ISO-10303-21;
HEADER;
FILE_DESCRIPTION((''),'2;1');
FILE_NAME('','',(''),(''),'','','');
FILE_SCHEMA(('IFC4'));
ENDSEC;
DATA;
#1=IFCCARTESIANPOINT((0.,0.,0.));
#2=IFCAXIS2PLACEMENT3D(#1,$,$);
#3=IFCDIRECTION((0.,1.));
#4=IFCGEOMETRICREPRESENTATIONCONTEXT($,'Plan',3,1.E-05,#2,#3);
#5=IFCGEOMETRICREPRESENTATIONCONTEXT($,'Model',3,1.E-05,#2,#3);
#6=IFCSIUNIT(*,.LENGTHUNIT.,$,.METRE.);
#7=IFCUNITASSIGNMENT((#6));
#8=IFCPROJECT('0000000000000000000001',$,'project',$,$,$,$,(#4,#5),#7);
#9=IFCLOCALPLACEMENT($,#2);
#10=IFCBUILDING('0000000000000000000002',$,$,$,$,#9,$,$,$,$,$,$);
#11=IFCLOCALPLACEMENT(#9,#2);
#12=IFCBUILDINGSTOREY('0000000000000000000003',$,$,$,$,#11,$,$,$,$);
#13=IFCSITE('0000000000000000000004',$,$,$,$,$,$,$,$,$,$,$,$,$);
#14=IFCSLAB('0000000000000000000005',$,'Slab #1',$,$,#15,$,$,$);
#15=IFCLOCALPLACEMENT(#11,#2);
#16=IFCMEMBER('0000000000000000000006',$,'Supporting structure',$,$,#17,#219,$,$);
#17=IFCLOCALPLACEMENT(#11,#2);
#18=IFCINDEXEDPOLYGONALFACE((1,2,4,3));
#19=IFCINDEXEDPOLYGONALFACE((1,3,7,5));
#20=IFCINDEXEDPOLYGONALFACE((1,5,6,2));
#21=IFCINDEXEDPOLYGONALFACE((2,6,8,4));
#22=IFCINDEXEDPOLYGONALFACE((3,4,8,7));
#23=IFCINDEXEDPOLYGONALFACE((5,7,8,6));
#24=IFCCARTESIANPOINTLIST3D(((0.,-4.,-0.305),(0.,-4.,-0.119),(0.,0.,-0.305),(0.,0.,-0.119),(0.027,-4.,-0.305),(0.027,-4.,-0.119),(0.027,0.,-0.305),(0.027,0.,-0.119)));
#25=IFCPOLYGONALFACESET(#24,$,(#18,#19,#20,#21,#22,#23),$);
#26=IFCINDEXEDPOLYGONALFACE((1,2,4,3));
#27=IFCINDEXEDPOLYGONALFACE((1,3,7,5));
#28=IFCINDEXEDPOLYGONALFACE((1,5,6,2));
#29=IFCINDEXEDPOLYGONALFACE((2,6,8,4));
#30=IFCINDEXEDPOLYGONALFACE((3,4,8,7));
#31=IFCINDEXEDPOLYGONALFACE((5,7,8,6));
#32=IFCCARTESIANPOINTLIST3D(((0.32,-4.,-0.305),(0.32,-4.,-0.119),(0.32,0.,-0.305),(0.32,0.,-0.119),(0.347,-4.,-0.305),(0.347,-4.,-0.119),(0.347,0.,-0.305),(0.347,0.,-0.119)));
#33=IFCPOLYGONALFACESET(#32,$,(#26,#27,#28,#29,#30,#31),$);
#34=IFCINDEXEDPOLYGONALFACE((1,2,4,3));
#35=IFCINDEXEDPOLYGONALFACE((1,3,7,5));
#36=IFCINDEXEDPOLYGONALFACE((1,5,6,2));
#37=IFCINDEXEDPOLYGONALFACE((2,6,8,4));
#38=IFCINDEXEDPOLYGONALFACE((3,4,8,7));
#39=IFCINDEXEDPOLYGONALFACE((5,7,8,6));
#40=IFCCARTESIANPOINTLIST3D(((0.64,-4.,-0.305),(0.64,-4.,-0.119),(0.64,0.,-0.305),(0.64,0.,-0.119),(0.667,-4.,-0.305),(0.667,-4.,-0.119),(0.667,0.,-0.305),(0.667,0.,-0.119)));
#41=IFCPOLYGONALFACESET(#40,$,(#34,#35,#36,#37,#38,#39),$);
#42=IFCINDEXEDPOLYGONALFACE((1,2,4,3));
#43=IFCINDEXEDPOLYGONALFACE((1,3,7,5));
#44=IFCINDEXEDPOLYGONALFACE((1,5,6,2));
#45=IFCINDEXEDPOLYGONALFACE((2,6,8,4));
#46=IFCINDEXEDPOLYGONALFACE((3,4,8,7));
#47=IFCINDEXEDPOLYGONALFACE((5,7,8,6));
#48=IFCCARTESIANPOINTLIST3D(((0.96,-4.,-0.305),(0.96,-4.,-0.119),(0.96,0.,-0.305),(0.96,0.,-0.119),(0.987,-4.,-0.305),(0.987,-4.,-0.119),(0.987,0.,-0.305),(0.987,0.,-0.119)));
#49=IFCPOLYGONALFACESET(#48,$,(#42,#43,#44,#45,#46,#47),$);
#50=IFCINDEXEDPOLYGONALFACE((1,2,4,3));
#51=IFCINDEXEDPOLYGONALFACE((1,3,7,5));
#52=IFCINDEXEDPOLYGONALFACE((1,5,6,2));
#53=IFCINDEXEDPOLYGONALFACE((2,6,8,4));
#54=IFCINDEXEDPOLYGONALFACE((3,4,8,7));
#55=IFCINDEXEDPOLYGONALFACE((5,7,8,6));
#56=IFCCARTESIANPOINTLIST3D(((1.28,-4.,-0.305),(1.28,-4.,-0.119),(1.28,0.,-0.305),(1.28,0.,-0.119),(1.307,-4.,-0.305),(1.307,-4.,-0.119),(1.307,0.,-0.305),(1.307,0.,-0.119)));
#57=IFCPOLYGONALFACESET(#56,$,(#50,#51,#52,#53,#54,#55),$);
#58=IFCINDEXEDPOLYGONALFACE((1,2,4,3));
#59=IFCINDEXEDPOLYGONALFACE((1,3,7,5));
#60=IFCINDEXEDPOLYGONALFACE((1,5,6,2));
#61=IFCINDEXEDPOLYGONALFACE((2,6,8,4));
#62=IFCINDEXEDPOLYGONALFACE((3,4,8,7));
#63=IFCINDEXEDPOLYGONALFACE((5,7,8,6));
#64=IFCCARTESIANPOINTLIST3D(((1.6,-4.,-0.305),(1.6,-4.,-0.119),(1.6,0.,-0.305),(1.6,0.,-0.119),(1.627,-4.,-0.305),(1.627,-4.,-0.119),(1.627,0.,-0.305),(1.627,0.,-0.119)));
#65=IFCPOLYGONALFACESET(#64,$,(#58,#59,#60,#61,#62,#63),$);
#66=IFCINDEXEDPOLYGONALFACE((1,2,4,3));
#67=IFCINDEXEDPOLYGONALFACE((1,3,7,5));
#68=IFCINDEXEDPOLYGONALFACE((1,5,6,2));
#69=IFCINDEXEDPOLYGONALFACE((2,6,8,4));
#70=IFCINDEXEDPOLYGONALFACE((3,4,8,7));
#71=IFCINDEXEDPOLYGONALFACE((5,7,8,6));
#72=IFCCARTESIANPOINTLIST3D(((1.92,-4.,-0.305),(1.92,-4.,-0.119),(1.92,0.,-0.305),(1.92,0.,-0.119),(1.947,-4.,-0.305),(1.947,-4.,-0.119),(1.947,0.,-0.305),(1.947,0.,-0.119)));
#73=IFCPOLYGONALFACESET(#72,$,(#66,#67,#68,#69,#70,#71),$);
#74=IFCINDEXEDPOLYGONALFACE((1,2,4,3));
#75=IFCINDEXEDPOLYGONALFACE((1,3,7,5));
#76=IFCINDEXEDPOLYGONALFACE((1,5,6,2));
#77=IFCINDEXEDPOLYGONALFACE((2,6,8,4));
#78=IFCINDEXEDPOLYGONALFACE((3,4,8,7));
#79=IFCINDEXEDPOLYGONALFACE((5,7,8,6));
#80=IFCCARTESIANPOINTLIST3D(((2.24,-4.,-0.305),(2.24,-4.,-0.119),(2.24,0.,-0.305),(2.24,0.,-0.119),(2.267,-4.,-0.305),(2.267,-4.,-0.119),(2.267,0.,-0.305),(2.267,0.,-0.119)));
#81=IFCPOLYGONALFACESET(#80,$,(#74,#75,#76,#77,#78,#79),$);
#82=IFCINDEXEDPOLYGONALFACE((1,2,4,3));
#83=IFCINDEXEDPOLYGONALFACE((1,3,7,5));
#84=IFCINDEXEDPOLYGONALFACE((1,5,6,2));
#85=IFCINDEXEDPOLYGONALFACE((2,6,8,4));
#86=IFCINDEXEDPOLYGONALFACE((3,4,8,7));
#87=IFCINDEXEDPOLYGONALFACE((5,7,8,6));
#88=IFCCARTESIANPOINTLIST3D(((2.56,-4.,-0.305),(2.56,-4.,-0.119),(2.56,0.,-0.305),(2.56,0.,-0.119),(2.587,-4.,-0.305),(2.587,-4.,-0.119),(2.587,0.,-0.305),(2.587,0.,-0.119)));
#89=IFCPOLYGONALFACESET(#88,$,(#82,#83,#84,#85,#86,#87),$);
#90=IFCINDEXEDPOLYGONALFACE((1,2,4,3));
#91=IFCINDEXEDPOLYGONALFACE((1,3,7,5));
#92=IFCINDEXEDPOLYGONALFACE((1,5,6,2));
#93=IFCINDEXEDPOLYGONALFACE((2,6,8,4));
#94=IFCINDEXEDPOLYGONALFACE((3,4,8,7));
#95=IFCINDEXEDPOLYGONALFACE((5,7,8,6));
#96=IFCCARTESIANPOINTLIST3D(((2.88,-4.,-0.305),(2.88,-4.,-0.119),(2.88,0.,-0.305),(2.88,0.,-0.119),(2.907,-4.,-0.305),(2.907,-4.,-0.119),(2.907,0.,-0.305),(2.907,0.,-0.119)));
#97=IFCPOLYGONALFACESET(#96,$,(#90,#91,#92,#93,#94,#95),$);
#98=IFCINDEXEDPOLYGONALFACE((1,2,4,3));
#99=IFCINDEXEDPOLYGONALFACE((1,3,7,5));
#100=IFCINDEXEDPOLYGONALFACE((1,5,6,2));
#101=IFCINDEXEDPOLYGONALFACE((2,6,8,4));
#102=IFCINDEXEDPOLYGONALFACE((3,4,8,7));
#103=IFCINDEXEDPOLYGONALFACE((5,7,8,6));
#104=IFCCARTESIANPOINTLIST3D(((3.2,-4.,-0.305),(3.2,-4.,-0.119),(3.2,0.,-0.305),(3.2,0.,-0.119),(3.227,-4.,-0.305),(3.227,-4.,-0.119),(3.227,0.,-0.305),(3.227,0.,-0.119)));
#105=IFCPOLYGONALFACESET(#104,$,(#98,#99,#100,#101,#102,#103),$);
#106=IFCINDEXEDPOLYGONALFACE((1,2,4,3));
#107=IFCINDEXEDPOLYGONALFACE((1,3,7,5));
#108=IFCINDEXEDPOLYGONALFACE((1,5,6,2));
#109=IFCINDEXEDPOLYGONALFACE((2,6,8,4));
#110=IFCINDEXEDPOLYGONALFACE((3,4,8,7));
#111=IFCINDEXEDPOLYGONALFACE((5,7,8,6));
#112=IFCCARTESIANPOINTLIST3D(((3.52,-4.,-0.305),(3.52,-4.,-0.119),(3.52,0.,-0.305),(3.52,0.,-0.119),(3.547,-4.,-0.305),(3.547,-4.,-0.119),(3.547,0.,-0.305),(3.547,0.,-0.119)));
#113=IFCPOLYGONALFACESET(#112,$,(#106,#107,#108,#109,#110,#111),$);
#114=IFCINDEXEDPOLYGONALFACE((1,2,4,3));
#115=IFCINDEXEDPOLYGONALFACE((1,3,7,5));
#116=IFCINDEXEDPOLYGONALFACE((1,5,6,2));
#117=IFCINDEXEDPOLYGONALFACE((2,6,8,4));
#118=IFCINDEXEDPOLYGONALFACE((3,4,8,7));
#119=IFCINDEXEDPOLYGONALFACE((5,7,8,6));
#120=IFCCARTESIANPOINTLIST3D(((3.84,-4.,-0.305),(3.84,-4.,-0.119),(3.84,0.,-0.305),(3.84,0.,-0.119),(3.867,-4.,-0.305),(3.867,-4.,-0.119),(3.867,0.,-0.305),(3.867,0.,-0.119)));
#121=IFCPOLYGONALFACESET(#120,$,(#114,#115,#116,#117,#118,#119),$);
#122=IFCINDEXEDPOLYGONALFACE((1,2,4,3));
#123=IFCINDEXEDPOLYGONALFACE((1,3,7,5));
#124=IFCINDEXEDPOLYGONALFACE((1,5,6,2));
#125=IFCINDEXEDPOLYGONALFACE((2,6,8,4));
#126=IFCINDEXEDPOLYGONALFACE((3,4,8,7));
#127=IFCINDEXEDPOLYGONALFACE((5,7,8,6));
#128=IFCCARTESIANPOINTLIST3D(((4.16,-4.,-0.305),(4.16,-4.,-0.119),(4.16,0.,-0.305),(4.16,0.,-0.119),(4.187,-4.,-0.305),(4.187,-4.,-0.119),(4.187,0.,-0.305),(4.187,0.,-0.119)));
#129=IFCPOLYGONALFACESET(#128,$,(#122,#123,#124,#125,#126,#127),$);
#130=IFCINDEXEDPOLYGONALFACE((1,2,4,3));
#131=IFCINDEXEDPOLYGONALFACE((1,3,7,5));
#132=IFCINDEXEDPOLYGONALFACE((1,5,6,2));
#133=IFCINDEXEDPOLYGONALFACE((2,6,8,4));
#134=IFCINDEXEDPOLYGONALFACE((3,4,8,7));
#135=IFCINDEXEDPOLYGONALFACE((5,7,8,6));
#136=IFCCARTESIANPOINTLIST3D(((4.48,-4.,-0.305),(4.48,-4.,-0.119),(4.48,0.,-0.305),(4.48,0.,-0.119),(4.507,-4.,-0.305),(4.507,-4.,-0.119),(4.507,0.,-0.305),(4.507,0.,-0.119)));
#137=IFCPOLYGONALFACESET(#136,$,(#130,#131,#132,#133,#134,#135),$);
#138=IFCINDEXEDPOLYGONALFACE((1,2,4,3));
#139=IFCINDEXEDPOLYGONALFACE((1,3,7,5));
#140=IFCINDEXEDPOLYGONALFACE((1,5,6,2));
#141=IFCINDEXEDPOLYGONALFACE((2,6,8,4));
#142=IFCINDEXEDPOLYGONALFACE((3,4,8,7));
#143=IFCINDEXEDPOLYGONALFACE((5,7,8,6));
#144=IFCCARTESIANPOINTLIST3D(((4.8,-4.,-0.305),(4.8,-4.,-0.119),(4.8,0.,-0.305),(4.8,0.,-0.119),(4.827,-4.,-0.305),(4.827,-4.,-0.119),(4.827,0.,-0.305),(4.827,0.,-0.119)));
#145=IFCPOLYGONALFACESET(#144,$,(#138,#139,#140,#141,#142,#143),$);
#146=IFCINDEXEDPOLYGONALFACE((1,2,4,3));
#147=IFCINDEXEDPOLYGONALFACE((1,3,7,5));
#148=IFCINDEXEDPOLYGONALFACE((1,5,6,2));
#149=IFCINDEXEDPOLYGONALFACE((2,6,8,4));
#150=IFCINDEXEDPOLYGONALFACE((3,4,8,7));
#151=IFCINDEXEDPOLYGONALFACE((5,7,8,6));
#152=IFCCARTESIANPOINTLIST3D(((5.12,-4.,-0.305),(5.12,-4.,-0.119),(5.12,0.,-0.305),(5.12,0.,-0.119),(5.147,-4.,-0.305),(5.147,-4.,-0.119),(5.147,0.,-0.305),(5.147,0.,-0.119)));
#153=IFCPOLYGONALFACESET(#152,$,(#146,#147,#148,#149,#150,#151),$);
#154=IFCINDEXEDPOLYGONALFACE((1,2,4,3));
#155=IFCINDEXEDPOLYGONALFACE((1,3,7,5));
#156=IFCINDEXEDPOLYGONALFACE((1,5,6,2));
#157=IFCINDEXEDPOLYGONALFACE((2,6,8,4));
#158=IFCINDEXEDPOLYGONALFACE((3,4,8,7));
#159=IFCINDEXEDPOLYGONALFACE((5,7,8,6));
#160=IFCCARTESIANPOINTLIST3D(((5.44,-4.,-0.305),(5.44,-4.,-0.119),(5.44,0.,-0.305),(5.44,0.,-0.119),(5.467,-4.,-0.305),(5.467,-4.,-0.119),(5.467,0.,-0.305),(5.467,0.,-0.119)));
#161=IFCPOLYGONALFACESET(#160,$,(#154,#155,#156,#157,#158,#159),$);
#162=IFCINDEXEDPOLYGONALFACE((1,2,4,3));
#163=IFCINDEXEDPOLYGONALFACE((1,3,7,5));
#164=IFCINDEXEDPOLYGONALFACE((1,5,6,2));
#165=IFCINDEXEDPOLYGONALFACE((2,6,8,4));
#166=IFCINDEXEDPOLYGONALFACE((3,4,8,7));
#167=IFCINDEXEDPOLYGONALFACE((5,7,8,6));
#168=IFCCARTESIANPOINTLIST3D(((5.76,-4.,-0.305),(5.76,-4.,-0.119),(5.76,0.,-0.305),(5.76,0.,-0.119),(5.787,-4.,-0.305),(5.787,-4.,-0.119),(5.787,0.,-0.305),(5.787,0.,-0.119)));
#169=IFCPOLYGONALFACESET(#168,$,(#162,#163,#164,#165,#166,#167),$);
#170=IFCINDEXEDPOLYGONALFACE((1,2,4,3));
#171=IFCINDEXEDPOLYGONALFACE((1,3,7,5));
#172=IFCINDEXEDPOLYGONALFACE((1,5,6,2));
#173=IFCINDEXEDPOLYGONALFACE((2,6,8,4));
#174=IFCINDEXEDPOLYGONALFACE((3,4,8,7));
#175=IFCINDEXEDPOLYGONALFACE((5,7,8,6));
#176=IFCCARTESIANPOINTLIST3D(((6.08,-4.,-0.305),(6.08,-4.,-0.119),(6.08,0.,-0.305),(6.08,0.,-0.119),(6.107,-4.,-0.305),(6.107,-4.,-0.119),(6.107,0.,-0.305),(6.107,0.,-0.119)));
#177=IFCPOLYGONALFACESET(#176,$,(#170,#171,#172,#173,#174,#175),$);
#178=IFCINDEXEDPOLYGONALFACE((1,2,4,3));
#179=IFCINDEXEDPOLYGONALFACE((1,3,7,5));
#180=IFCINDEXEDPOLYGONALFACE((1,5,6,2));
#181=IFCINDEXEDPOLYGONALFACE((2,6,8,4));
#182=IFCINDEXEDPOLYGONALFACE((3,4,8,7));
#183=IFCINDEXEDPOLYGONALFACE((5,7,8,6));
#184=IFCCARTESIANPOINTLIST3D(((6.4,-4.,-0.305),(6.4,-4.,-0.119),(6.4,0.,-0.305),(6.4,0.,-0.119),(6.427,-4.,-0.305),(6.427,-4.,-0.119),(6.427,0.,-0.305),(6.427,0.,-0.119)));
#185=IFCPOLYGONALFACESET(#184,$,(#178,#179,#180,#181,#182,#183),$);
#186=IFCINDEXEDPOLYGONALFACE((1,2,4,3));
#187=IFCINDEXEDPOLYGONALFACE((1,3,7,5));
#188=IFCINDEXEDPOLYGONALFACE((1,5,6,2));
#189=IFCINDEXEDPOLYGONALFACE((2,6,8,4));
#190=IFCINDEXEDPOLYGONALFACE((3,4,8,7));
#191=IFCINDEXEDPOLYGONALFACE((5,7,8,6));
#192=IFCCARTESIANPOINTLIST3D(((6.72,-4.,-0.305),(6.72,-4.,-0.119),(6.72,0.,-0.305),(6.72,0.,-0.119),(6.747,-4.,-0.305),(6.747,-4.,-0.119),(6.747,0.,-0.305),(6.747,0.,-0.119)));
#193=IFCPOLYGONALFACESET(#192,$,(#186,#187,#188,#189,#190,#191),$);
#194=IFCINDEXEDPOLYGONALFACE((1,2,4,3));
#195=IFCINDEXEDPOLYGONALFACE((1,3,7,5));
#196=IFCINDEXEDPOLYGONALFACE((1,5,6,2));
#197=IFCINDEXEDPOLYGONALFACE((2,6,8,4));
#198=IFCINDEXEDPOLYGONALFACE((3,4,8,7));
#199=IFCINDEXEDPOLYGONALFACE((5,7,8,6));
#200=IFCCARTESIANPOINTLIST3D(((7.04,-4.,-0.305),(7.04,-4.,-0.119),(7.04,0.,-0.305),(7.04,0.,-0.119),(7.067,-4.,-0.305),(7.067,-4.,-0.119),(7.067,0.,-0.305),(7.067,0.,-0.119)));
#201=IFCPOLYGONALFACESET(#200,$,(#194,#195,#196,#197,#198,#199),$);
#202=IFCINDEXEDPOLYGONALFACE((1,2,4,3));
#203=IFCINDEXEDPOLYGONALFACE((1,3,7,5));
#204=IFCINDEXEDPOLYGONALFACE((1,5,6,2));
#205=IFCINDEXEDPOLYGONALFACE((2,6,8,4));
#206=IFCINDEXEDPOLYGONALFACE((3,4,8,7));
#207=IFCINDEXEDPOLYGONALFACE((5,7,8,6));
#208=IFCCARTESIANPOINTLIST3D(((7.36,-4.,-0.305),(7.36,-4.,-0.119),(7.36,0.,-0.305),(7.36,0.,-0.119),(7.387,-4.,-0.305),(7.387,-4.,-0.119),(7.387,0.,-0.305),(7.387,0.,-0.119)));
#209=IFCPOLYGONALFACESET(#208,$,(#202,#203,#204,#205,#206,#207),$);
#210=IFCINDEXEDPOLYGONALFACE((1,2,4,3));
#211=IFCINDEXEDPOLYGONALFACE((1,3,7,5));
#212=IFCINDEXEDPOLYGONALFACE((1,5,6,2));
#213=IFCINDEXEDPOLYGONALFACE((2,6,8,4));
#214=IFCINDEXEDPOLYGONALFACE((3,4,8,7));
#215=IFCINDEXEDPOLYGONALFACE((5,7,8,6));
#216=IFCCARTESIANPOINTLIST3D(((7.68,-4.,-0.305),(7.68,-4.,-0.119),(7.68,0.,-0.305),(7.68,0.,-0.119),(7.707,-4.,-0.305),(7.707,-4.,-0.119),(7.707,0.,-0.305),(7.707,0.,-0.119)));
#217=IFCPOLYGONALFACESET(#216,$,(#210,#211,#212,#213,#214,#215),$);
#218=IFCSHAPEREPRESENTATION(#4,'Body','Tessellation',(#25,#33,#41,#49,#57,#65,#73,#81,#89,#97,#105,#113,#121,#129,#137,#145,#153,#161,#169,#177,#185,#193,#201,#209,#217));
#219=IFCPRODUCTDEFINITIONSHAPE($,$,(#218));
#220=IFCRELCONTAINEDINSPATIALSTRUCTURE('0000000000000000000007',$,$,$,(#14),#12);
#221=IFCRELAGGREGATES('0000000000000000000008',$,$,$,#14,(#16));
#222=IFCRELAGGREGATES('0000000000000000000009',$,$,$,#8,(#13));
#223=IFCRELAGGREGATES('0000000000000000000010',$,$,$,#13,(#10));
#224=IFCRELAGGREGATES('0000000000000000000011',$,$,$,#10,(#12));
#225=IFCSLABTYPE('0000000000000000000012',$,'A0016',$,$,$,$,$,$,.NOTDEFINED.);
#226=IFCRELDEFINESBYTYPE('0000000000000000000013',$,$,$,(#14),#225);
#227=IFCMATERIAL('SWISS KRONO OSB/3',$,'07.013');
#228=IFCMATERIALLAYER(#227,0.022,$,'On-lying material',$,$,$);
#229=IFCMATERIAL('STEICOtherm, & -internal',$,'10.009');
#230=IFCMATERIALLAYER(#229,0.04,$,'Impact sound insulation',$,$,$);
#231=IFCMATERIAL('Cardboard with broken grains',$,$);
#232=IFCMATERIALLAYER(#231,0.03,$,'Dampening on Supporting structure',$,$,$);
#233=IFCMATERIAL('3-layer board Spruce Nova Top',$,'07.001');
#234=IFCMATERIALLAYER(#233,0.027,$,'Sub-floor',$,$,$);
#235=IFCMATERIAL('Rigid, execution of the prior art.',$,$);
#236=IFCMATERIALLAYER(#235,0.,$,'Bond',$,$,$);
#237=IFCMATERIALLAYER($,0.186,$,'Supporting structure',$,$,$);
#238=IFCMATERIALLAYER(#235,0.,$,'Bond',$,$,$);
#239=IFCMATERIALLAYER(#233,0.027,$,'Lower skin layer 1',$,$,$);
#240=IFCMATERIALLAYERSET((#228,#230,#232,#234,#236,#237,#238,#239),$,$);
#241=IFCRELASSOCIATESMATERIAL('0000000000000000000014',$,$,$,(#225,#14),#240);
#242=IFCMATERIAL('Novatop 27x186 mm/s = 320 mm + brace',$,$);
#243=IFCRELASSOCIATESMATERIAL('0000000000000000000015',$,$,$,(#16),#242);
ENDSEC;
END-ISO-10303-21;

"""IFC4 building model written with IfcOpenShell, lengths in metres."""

from ifc_helpers import new_model, si_unit, direction, frame, frame_2d, origin, place, context, project, spatial, rectangle, extrude, material, layer, layer_set, type_object, element, aggregate, save


model = new_model("IFC4")

# Units and contexts
plan_context = context("Plan", 3, precision=1e-05, world=origin(), true_north=direction((0.0, 1.0)))
model_context = context("Model", 3, precision=1e-05, world=origin(), true_north=direction((0.0, 1.0)))
ifc_project = project(units=[si_unit("LENGTHUNIT", "METRE")], contexts=[plan_context, model_context])

# Site, building, storey
site = spatial("IfcSite", under=ifc_project)
building_placement = place(None, origin())
building = spatial("IfcBuilding", under=site, at=building_placement)
storey_placement = place(building_placement, origin())
storey = spatial("IfcBuildingStorey", under=building, at=storey_placement)

# Slab, member
ifc_material_1 = material(Name="SWISS KRONO OSB/3", Category="07.013")
ifc_layer_1 = layer(ifc_material_1, 0.022, Name="On-lying material")
ifc_material_2 = material(Name="STEICOtherm, & -internal", Category="10.009")
ifc_layer_2 = layer(ifc_material_2, 0.04, Name="Impact sound insulation")
ifc_material_3 = material(Name="Cardboard with broken grains")
ifc_layer_3 = layer(ifc_material_3, 0.03, Name="Dampening on Supporting structure")
ifc_material_4 = material(Name="3-layer board Spruce Nova Top", Category="07.001")
ifc_layer_4 = layer(ifc_material_4, 0.027, Name="Sub-floor")
ifc_material_5 = material(Name="Rigid, execution of the prior art.")
ifc_layer_5 = layer(ifc_material_5, 0.0, Name="Bond")
ifc_layer_6 = layer(None, 0.186, Name="Supporting structure")
ifc_layer_7 = layer(ifc_material_5, 0.0, Name="Bond")
ifc_layer_8 = layer(ifc_material_4, 0.027, Name="Lower skin layer 1")
ifc_layer_set = layer_set([ifc_layer_1, ifc_layer_2, ifc_layer_3, ifc_layer_4, ifc_layer_5, ifc_layer_6, ifc_layer_7, ifc_layer_8])
slab_type = type_object("IfcSlabType", Name="A0016", PredefinedType="NOTDEFINED", material=ifc_layer_set)
slab_placement = place(None, frame((0.0, 0.0, 0.0), z_axis=(0.0, 0.0, -1.0), x_axis=(1.0, 0.0, 0.0)))
slab = element("IfcSlab", 1, at=slab_placement, inside=storey, type_object=slab_type, material=ifc_layer_set, Name="Slab #1")
ifc_material_6 = material(Name="Novatop 27x186 mm/s = 320 mm + brace")
member_1_placement = place(slab_placement, origin())
member_1 = element("IfcMember", 2, at=member_1_placement, material=ifc_material_6, Name="Supporting structure", context=plan_context, shape_type="SweptSolid", body=[
    extrude(rectangle(XDim=0.027, YDim=0.186, at=frame_2d((0.0135, 0.093), x_axis=(1.0, 0.0))), frame((0.0, 4.0, 0.119), z_axis=(0.0, -1.0, 0.0), x_axis=(1.0, 0.0, 0.0)), (0.0, 0.0, 1.0), 4.0),
    extrude(rectangle(XDim=0.027, YDim=0.186, at=frame_2d((0.0135, 0.093), x_axis=(1.0, 0.0))), frame((0.32, 4.0, 0.119), z_axis=(0.0, -1.0, 0.0), x_axis=(1.0, 0.0, 0.0)), (0.0, 0.0, 1.0), 4.0),
    extrude(rectangle(XDim=0.027, YDim=0.186, at=frame_2d((0.0135, 0.093), x_axis=(1.0, 0.0))), frame((0.64, 4.0, 0.119), z_axis=(0.0, -1.0, 0.0), x_axis=(1.0, 0.0, 0.0)), (0.0, 0.0, 1.0), 4.0),
    extrude(rectangle(XDim=0.027, YDim=0.186, at=frame_2d((0.0135, 0.093), x_axis=(1.0, 0.0))), frame((0.96, 4.0, 0.119), z_axis=(0.0, -1.0, 0.0), x_axis=(1.0, 0.0, 0.0)), (0.0, 0.0, 1.0), 4.0),
    extrude(rectangle(XDim=0.027, YDim=0.186, at=frame_2d((0.0135, 0.093), x_axis=(1.0, 0.0))), frame((1.28, 4.0, 0.119), z_axis=(0.0, -1.0, 0.0), x_axis=(1.0, 0.0, 0.0)), (0.0, 0.0, 1.0), 4.0),
    extrude(rectangle(XDim=0.027, YDim=0.186, at=frame_2d((0.0135, 0.093), x_axis=(1.0, 0.0))), frame((1.6, 4.0, 0.119), z_axis=(0.0, -1.0, 0.0), x_axis=(1.0, 0.0, 0.0)), (0.0, 0.0, 1.0), 4.0),
    extrude(rectangle(XDim=0.027, YDim=0.186, at=frame_2d((0.0135, 0.093), x_axis=(1.0, 0.0))), frame((1.92, 4.0, 0.119), z_axis=(0.0, -1.0, 0.0), x_axis=(1.0, 0.0, 0.0)), (0.0, 0.0, 1.0), 4.0),
    extrude(rectangle(XDim=0.027, YDim=0.186, at=frame_2d((0.0135, 0.093), x_axis=(1.0, 0.0))), frame((2.24, 4.0, 0.119), z_axis=(0.0, -1.0, 0.0), x_axis=(1.0, 0.0, 0.0)), (0.0, 0.0, 1.0), 4.0),
    extrude(rectangle(XDim=0.027, YDim=0.186, at=frame_2d((0.0135, 0.093), x_axis=(1.0, 0.0))), frame((2.56, 4.0, 0.119), z_axis=(0.0, -1.0, 0.0), x_axis=(1.0, 0.0, 0.0)), (0.0, 0.0, 1.0), 4.0),
    extrude(rectangle(XDim=0.027, YDim=0.186, at=frame_2d((0.0135, 0.093), x_axis=(1.0, 0.0))), frame((2.88, 4.0, 0.119), z_axis=(0.0, -1.0, 0.0), x_axis=(1.0, 0.0, 0.0)), (0.0, 0.0, 1.0), 4.0),
    extrude(rectangle(XDim=0.027, YDim=0.186, at=frame_2d((0.0135, 0.093), x_axis=(1.0, 0.0))), frame((3.2, 4.0, 0.119), z_axis=(0.0, -1.0, 0.0), x_axis=(1.0, 0.0, 0.0)), (0.0, 0.0, 1.0), 4.0),
    extrude(rectangle(XDim=0.027, YDim=0.186, at=frame_2d((0.0135, 0.093), x_axis=(1.0, 0.0))), frame((3.52, 4.0, 0.119), z_axis=(0.0, -1.0, 0.0), x_axis=(1.0, 0.0, 0.0)), (0.0, 0.0, 1.0), 4.0),
    extrude(rectangle(XDim=0.027, YDim=0.186, at=frame_2d((0.0135, 0.093), x_axis=(1.0, 0.0))), frame((3.84, 4.0, 0.119), z_axis=(0.0, -1.0, 0.0), x_axis=(1.0, 0.0, 0.0)), (0.0, 0.0, 1.0), 4.0),
    extrude(rectangle(XDim=0.027, YDim=0.186, at=frame_2d((0.0135, 0.093), x_axis=(1.0, 0.0))), frame((4.16, 4.0, 0.119), z_axis=(0.0, -1.0, 0.0), x_axis=(1.0, 0.0, 0.0)), (0.0, 0.0, 1.0), 4.0),
    extrude(rectangle(XDim=0.027, YDim=0.186, at=frame_2d((0.0135, 0.093), x_axis=(1.0, 0.0))), frame((4.48, 4.0, 0.119), z_axis=(0.0, -1.0, 0.0), x_axis=(1.0, 0.0, 0.0)), (0.0, 0.0, 1.0), 4.0),
    extrude(rectangle(XDim=0.027, YDim=0.186, at=frame_2d((0.0135, 0.093), x_axis=(1.0, 0.0))), frame((4.8, 4.0, 0.119), z_axis=(0.0, -1.0, 0.0), x_axis=(1.0, 0.0, 0.0)), (0.0, 0.0, 1.0), 4.0),
    extrude(rectangle(XDim=0.027, YDim=0.186, at=frame_2d((0.0135, 0.093), x_axis=(1.0, 0.0))), frame((5.12, 4.0, 0.119), z_axis=(0.0, -1.0, 0.0), x_axis=(1.0, 0.0, 0.0)), (0.0, 0.0, 1.0), 4.0),
    extrude(rectangle(XDim=0.027, YDim=0.186, at=frame_2d((0.0135, 0.093), x_axis=(1.0, 0.0))), frame((5.44, 4.0, 0.119), z_axis=(0.0, -1.0, 0.0), x_axis=(1.0, 0.0, 0.0)), (0.0, 0.0, 1.0), 4.0),
    extrude(rectangle(XDim=0.027, YDim=0.186, at=frame_2d((0.0135, 0.093), x_axis=(1.0, 0.0))), frame((5.76, 4.0, 0.119), z_axis=(0.0, -1.0, 0.0), x_axis=(1.0, 0.0, 0.0)), (0.0, 0.0, 1.0), 4.0),
    extrude(rectangle(XDim=0.027, YDim=0.186, at=frame_2d((0.0135, 0.093), x_axis=(1.0, 0.0))), frame((6.08, 4.0, 0.119), z_axis=(0.0, -1.0, 0.0), x_axis=(1.0, 0.0, 0.0)), (0.0, 0.0, 1.0), 4.0),
    extrude(rectangle(XDim=0.027, YDim=0.186, at=frame_2d((0.0135, 0.093), x_axis=(1.0, 0.0))), frame((6.4, 4.0, 0.119), z_axis=(0.0, -1.0, 0.0), x_axis=(1.0, 0.0, 0.0)), (0.0, 0.0, 1.0), 4.0),
    extrude(rectangle(XDim=0.027, YDim=0.186, at=frame_2d((0.0135, 0.093), x_axis=(1.0, 0.0))), frame((6.72, 4.0, 0.119), z_axis=(0.0, -1.0, 0.0), x_axis=(1.0, 0.0, 0.0)), (0.0, 0.0, 1.0), 4.0),
    extrude(rectangle(XDim=0.027, YDim=0.186, at=frame_2d((0.0135, 0.093), x_axis=(1.0, 0.0))), frame((7.04, 4.0, 0.119), z_axis=(0.0, -1.0, 0.0), x_axis=(1.0, 0.0, 0.0)), (0.0, 0.0, 1.0), 4.0),
    extrude(rectangle(XDim=0.027, YDim=0.186, at=frame_2d((0.0135, 0.093), x_axis=(1.0, 0.0))), frame((7.36, 4.0, 0.119), z_axis=(0.0, -1.0, 0.0), x_axis=(1.0, 0.0, 0.0)), (0.0, 0.0, 1.0), 4.0),
    extrude(rectangle(XDim=0.027, YDim=0.186, at=frame_2d((0.0135, 0.093), x_axis=(1.0, 0.0))), frame((7.68, 4.0, 0.119), z_axis=(0.0, -1.0, 0.0), x_axis=(1.0, 0.0, 0.0)), (0.0, 0.0, 1.0), 4.0),
])
aggregate(slab, [member_1])

save(model, "model.ifc")
